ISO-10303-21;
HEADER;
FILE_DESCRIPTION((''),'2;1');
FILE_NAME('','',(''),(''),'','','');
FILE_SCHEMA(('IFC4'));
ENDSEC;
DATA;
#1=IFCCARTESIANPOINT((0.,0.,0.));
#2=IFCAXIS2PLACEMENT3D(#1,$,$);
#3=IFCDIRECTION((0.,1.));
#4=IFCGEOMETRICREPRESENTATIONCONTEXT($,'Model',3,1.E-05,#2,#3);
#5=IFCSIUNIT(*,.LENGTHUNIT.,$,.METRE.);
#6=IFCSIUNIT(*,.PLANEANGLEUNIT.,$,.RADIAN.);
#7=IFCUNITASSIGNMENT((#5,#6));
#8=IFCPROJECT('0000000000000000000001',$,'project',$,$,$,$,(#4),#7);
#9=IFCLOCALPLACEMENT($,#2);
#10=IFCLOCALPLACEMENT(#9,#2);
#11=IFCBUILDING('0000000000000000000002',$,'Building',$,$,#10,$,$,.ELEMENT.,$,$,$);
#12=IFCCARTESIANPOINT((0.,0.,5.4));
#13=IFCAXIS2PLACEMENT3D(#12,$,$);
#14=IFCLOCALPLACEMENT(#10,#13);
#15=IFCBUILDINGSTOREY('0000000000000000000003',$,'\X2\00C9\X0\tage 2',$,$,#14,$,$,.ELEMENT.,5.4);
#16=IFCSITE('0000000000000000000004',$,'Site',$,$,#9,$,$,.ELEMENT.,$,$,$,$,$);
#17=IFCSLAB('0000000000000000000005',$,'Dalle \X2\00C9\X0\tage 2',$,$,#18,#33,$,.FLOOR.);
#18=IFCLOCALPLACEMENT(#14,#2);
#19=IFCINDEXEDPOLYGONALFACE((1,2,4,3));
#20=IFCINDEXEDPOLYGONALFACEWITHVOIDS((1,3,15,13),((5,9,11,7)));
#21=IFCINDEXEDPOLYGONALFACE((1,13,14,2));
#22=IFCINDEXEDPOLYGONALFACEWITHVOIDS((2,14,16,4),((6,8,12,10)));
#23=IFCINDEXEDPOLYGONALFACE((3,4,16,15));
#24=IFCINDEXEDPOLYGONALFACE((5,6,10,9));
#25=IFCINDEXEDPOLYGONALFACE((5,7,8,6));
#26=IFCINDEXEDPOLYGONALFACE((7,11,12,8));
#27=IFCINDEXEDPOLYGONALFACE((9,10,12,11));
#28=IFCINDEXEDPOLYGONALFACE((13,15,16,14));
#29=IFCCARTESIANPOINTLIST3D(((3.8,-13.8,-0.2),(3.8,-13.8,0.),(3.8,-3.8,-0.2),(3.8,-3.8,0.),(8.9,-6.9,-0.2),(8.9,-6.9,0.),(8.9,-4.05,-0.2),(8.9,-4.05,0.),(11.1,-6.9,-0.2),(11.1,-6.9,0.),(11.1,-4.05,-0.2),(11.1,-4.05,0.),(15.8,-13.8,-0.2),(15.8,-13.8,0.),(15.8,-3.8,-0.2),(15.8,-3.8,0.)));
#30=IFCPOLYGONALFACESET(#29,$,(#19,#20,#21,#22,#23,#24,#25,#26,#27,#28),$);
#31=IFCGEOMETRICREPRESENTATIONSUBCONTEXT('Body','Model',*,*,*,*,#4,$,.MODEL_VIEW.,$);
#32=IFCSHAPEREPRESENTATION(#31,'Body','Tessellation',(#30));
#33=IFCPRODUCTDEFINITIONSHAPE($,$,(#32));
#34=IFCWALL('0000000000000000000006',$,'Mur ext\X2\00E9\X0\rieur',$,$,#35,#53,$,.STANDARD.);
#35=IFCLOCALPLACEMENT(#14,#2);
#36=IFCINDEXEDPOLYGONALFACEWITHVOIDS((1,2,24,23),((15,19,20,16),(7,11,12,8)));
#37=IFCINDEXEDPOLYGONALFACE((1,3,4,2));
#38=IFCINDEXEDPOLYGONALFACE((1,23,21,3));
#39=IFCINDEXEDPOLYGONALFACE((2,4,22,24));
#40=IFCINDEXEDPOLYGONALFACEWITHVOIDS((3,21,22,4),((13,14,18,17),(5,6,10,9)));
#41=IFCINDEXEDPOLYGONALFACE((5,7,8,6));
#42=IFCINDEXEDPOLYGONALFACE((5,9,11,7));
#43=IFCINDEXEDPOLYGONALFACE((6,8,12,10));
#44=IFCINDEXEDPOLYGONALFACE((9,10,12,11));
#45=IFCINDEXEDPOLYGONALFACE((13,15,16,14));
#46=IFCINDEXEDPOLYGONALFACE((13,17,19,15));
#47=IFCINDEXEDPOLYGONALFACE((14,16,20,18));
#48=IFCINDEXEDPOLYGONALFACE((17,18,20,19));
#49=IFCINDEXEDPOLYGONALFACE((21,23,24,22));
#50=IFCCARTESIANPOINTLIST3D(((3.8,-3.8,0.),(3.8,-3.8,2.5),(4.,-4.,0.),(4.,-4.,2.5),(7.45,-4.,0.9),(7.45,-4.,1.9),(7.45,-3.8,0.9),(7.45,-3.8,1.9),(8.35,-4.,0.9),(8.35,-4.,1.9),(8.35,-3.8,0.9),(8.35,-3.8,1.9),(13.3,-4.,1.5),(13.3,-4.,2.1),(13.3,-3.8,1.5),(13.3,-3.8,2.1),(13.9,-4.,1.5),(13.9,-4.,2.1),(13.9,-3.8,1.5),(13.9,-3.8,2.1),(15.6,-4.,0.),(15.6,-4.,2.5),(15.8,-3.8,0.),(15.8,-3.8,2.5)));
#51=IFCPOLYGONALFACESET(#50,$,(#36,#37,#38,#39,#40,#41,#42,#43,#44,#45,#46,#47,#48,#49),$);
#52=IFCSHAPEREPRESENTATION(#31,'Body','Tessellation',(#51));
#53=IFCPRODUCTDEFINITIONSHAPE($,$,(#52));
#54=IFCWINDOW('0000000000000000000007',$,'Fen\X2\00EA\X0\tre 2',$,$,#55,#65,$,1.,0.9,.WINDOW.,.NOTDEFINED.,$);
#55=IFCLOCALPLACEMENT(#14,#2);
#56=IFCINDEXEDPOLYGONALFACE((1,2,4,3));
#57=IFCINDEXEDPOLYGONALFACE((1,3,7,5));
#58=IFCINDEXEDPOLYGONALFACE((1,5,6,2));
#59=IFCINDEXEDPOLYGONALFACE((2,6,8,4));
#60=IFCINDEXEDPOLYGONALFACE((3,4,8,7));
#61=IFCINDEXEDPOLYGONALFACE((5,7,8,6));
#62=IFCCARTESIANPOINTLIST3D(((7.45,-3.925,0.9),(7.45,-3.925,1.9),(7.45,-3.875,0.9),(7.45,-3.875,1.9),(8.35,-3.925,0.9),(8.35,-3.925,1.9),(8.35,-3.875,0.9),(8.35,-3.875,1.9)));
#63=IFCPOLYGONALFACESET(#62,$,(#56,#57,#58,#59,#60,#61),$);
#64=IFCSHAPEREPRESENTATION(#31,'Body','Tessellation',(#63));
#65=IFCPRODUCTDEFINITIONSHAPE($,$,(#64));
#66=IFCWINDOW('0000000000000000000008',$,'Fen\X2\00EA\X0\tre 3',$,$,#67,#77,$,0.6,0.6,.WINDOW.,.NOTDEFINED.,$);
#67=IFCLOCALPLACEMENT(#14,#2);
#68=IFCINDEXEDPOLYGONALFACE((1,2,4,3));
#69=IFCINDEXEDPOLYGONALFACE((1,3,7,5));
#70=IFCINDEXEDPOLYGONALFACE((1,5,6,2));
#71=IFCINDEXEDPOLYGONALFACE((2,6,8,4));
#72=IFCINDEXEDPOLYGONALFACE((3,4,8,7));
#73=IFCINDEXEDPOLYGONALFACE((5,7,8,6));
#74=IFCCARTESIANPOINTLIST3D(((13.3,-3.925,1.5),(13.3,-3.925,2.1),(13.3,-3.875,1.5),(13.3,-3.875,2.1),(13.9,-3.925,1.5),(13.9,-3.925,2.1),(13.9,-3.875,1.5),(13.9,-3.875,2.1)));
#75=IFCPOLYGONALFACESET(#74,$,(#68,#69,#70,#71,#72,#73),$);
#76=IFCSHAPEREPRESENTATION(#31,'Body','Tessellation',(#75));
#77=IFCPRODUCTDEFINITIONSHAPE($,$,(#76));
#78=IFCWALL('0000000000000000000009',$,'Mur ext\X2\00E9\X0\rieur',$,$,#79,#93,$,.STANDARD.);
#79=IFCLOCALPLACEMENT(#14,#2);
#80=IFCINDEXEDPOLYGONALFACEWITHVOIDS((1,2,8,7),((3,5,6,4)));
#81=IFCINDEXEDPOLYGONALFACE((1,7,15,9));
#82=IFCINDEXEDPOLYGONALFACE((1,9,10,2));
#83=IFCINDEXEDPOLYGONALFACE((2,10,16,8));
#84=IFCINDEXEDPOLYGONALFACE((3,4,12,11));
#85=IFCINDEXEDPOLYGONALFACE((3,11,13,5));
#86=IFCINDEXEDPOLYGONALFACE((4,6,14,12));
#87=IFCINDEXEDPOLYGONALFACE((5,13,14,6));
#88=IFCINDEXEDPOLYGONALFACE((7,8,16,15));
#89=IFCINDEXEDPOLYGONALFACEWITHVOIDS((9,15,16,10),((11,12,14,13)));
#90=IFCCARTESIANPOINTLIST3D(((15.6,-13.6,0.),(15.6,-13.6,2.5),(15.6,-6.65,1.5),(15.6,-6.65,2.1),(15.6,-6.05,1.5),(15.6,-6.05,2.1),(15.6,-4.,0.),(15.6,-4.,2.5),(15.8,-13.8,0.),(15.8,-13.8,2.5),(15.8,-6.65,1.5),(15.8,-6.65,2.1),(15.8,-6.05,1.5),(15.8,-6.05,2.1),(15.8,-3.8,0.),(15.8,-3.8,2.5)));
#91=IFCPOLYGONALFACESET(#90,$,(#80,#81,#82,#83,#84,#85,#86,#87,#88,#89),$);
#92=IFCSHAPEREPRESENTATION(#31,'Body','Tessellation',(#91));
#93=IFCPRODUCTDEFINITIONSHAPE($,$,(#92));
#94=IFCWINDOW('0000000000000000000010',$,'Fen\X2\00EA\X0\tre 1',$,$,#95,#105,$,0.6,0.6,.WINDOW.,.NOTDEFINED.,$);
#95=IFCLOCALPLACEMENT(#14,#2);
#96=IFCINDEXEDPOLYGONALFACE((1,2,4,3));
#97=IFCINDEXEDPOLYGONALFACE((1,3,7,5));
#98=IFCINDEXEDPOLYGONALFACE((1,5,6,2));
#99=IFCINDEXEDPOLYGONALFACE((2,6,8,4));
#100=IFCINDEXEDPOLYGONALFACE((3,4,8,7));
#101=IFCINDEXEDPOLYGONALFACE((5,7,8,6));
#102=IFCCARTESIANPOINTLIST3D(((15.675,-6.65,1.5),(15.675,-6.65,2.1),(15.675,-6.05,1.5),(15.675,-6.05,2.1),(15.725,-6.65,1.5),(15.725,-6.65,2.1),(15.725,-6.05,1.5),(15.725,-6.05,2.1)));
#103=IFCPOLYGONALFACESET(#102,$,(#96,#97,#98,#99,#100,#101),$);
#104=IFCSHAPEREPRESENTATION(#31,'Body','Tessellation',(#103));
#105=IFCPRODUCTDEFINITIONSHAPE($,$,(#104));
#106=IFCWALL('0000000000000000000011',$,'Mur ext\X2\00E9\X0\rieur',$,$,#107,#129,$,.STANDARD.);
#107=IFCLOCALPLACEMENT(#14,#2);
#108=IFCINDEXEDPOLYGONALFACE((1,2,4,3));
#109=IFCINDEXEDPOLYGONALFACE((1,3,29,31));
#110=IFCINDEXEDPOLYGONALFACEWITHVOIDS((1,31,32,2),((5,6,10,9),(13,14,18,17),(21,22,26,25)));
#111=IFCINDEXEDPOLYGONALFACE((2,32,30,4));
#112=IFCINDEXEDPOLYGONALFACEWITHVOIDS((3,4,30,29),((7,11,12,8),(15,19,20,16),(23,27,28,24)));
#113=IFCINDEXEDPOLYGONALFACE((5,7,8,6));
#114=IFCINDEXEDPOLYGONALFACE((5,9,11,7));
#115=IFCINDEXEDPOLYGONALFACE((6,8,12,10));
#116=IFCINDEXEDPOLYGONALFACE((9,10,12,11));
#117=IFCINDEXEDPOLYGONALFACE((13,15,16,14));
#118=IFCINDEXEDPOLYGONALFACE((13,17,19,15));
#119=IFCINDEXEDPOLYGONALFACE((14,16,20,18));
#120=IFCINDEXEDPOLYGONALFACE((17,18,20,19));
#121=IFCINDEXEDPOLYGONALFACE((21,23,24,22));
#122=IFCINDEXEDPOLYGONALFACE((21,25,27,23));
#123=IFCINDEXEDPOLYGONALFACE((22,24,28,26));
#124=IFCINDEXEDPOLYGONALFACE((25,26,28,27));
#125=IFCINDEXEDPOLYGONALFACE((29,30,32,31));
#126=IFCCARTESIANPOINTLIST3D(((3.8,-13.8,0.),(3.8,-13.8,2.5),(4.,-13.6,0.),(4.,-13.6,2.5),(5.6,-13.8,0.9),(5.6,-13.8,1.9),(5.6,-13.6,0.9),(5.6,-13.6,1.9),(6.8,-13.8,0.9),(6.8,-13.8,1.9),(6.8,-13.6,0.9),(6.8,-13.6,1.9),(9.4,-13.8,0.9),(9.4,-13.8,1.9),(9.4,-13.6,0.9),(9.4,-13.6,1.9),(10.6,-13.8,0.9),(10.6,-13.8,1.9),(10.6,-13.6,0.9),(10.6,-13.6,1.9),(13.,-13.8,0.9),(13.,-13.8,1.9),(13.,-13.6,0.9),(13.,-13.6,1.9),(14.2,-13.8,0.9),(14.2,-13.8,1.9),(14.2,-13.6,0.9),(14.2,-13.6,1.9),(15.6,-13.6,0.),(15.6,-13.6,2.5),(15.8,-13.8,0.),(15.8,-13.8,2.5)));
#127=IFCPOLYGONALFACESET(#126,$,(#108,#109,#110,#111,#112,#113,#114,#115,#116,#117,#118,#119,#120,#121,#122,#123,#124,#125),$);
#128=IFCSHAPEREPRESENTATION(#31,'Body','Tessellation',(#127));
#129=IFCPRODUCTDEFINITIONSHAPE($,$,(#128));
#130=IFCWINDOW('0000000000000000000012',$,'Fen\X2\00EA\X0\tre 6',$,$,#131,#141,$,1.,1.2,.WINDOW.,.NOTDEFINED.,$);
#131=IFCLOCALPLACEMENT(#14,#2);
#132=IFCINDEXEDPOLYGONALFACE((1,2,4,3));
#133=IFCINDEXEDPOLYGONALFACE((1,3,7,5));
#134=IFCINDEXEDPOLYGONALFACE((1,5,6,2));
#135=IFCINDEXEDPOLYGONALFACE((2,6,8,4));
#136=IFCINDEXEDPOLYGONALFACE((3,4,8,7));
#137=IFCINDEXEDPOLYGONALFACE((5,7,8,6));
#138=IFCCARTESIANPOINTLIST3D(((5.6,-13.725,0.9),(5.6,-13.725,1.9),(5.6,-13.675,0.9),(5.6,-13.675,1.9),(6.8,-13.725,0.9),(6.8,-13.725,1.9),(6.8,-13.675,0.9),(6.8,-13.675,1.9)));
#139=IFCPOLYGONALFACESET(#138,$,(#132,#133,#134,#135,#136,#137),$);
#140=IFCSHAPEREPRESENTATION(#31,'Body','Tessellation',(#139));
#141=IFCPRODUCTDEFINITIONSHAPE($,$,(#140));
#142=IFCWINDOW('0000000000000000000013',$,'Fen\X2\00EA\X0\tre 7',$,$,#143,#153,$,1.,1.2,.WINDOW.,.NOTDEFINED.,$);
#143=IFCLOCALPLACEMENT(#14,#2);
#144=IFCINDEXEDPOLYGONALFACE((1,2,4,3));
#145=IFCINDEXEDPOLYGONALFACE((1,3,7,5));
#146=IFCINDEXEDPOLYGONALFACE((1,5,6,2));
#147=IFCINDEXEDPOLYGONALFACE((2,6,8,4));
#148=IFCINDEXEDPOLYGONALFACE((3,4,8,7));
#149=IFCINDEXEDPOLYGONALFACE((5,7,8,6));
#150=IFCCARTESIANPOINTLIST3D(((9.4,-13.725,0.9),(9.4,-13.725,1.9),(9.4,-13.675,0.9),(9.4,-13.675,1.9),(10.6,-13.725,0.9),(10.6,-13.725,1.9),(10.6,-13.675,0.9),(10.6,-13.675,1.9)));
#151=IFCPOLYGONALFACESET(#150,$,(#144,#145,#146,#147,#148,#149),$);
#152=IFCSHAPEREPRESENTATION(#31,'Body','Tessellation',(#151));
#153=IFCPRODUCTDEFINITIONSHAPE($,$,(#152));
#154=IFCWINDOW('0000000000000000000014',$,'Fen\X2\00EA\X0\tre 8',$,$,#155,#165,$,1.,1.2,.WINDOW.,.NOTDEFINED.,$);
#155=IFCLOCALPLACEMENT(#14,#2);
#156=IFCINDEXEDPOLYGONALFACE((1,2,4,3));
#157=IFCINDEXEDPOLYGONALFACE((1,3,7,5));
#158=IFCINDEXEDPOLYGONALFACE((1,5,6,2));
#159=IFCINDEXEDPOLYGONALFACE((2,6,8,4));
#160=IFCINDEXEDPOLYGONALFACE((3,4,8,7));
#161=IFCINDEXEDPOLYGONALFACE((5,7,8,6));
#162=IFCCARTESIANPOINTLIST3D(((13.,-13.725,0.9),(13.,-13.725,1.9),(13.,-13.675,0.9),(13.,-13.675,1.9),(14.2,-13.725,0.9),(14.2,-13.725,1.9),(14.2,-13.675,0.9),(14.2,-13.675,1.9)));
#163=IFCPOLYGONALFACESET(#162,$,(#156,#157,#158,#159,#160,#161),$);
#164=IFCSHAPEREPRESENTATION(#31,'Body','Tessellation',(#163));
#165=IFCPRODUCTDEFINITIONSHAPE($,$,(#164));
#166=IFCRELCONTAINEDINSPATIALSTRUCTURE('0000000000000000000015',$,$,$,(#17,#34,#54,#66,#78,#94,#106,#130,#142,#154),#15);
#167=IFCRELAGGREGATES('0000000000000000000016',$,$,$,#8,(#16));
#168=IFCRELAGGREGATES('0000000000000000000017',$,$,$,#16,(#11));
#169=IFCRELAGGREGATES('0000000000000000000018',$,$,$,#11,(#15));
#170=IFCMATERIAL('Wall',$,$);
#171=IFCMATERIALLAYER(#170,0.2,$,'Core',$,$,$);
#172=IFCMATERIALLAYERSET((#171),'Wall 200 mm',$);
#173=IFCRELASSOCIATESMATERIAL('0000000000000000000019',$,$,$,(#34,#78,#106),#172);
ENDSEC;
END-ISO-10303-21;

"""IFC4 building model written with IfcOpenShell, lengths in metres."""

from ifc_helpers import new_model, si_unit, direction, frame, origin, origin_2d, place, context, subcontext, project, spatial, polyline, rectangle, outline, extrude, material, layer, layer_set, layer_usage, element, fill, save


model = new_model("IFC4")

# Units and contexts
model_context = context("Model", 3, precision=1e-05, world=origin(), true_north=direction((0.0, 1.0)))
body_context = subcontext(model_context, "Body", "Model", "MODEL_VIEW")
ifc_project = project(units=[si_unit("LENGTHUNIT", "METRE"), si_unit("PLANEANGLEUNIT", "RADIAN")], contexts=[model_context])

# Site, building, storey
site_placement = place(None, origin())
site = spatial("IfcSite", under=ifc_project, at=site_placement, Name="Site", CompositionType="ELEMENT")
building_placement = place(site_placement, origin())
building = spatial("IfcBuilding", under=site, at=building_placement, Name="Building", CompositionType="ELEMENT")
storey_placement = place(building_placement, frame((0.0, 0.0, 5.4)))
storey = spatial("IfcBuildingStorey", under=building, at=storey_placement, Name="Étage 2", CompositionType="ELEMENT", Elevation=5.4)

# Slab
slab_placement = place(storey_placement, origin())
element("IfcSlab", 1, at=slab_placement, inside=storey, Name="Dalle Étage 2", PredefinedType="FLOOR", context=body_context, shape_type="SweptSolid", body=[
    extrude(outline(polyline([(3.8, -13.8), (15.8, -13.8), (15.8, -3.8), (3.8, -3.8), (3.8, -13.8)]), holes=[polyline([(11.1, -4.05), (11.1, -6.9), (8.9, -6.9), (8.9, -4.05), (11.1, -4.05)])]), frame((0.0, 0.0, -0.2)), (0.0, 0.0, 1.0), 0.2),
])

# Wall, openings, windows
ifc_material = material(Name="Wall")
ifc_layer = layer(ifc_material, 0.2, Name="Core")
ifc_layer_set = layer_set([ifc_layer], Name="Wall 200 mm")
ifc_layer_usage = layer_usage(ifc_layer_set, "AXIS2", "POSITIVE", -0.1)
wall_1_placement = place(storey_placement, frame((3.9, -3.9, 0.0)))
wall_1 = element("IfcWall", 2, at=wall_1_placement, inside=storey, material=ifc_layer_usage, Name="Mur extérieur", PredefinedType="STANDARD", context=body_context, shape_type="SweptSolid", body=[
    extrude(outline(polyline([(0.0, 0.0), (0.1, -0.1), (11.7, -0.1), (11.8, 0.0), (11.9, 0.1), (-0.1, 0.1), (0.0, 0.0)])), origin(), (0.0, 0.0, 1.0), 2.5),
])
opening_1_placement = place(wall_1_placement, frame((4.0, 0.0, 0.9)))
opening_1 = element("IfcOpeningElement", 3, at=opening_1_placement, cuts=wall_1, PredefinedType="OPENING", context=body_context, shape_type="SweptSolid", body=[
    extrude(rectangle(XDim=0.9, YDim=0.4, at=origin_2d()), origin(), (0.0, 0.0, 1.0), 1.0),
])
opening_2_placement = place(wall_1_placement, frame((9.7, 0.0, 1.5)))
opening_2 = element("IfcOpeningElement", 4, at=opening_2_placement, cuts=wall_1, PredefinedType="OPENING", context=body_context, shape_type="SweptSolid", body=[
    extrude(rectangle(XDim=0.6, YDim=0.4, at=origin_2d()), origin(), (0.0, 0.0, 1.0), 0.6),
])
window_1_placement = place(opening_1_placement, origin())
window_1 = element("IfcWindow", 5, at=window_1_placement, inside=storey, Name="Fenêtre 2", OverallHeight=1.0, OverallWidth=0.9, PartitioningType="NOTDEFINED", PredefinedType="WINDOW", context=body_context, shape_type="SweptSolid", body=[
    extrude(rectangle(XDim=0.9, YDim=0.05, at=origin_2d()), origin(), (0.0, 0.0, 1.0), 1.0),
])
fill(opening_1, window_1)
window_2_placement = place(opening_2_placement, origin())
window_2 = element("IfcWindow", 6, at=window_2_placement, inside=storey, Name="Fenêtre 3", OverallHeight=0.6, OverallWidth=0.6, PartitioningType="NOTDEFINED", PredefinedType="WINDOW", context=body_context, shape_type="SweptSolid", body=[
    extrude(rectangle(XDim=0.6, YDim=0.05, at=origin_2d()), origin(), (0.0, 0.0, 1.0), 0.6),
])
fill(opening_2, window_2)

# Wall, opening, window
wall_2_placement = place(storey_placement, frame((15.7, -3.9, 0.0), z_axis=(0.0, 0.0, 1.0), x_axis=(0.0, -1.0, 0.0)))
wall_2 = element("IfcWall", 7, at=wall_2_placement, inside=storey, material=ifc_layer_usage, Name="Mur extérieur", PredefinedType="STANDARD", context=body_context, shape_type="SweptSolid", body=[
    extrude(outline(polyline([(0.0, 0.0), (0.1, -0.1), (9.7, -0.1), (9.8, 0.0), (9.9, 0.1), (-0.1, 0.1), (0.0, 0.0)])), origin(), (0.0, 0.0, 1.0), 2.5),
])
opening_3_placement = place(wall_2_placement, frame((2.45, 0.0, 1.5)))
opening_3 = element("IfcOpeningElement", 8, at=opening_3_placement, cuts=wall_2, PredefinedType="OPENING", context=body_context, shape_type="SweptSolid", body=[
    extrude(rectangle(XDim=0.6, YDim=0.4, at=origin_2d()), origin(), (0.0, 0.0, 1.0), 0.6),
])
window_3_placement = place(opening_3_placement, origin())
window_3 = element("IfcWindow", 9, at=window_3_placement, inside=storey, Name="Fenêtre 1", OverallHeight=0.6, OverallWidth=0.6, PartitioningType="NOTDEFINED", PredefinedType="WINDOW", context=body_context, shape_type="SweptSolid", body=[
    extrude(rectangle(XDim=0.6, YDim=0.05, at=origin_2d()), origin(), (0.0, 0.0, 1.0), 0.6),
])
fill(opening_3, window_3)

# Wall, openings, windows
wall_3_placement = place(storey_placement, frame((15.7, -13.7, 0.0), z_axis=(0.0, 0.0, 1.0), x_axis=(-1.0, 0.0, 0.0)))
wall_3 = element("IfcWall", 10, at=wall_3_placement, inside=storey, material=ifc_layer_usage, Name="Mur extérieur", PredefinedType="STANDARD", context=body_context, shape_type="SweptSolid", body=[
    extrude(outline(polyline([(0.0, 0.0), (0.1, -0.1), (11.7, -0.1), (11.8, 0.0), (11.9, 0.1), (-0.1, 0.1), (0.0, 0.0)])), origin(), (0.0, 0.0, 1.0), 2.5),
])
opening_4_placement = place(wall_3_placement, frame((9.5, 0.0, 0.9), z_axis=(0.0, 0.0, 1.0), x_axis=(1.0, 0.0, 0.0)))
opening_4 = element("IfcOpeningElement", 11, at=opening_4_placement, cuts=wall_3, PredefinedType="OPENING", context=body_context, shape_type="SweptSolid", body=[
    extrude(rectangle(XDim=1.2, YDim=0.4, at=origin_2d()), origin(), (0.0, 0.0, 1.0), 1.0),
])
opening_5_placement = place(wall_3_placement, frame((5.7, 0.0, 0.9), z_axis=(0.0, 0.0, 1.0), x_axis=(1.0, 0.0, 0.0)))
opening_5 = element("IfcOpeningElement", 12, at=opening_5_placement, cuts=wall_3, PredefinedType="OPENING", context=body_context, shape_type="SweptSolid", body=[
    extrude(rectangle(XDim=1.2, YDim=0.4, at=origin_2d()), origin(), (0.0, 0.0, 1.0), 1.0),
])
opening_6_placement = place(wall_3_placement, frame((2.1, 0.0, 0.9), z_axis=(0.0, 0.0, 1.0), x_axis=(1.0, 0.0, 0.0)))
opening_6 = element("IfcOpeningElement", 13, at=opening_6_placement, cuts=wall_3, PredefinedType="OPENING", context=body_context, shape_type="SweptSolid", body=[
    extrude(rectangle(XDim=1.2, YDim=0.4, at=origin_2d()), origin(), (0.0, 0.0, 1.0), 1.0),
])
window_4_placement = place(opening_4_placement, origin())
window_4 = element("IfcWindow", 14, at=window_4_placement, inside=storey, Name="Fenêtre 6", OverallHeight=1.0, OverallWidth=1.2, PartitioningType="NOTDEFINED", PredefinedType="WINDOW", context=body_context, shape_type="SweptSolid", body=[
    extrude(rectangle(XDim=1.2, YDim=0.05, at=origin_2d()), origin(), (0.0, 0.0, 1.0), 1.0),
])
fill(opening_4, window_4)
window_5_placement = place(opening_5_placement, origin())
window_5 = element("IfcWindow", 15, at=window_5_placement, inside=storey, Name="Fenêtre 7", OverallHeight=1.0, OverallWidth=1.2, PartitioningType="NOTDEFINED", PredefinedType="WINDOW", context=body_context, shape_type="SweptSolid", body=[
    extrude(rectangle(XDim=1.2, YDim=0.05, at=origin_2d()), origin(), (0.0, 0.0, 1.0), 1.0),
])
fill(opening_5, window_5)
window_6_placement = place(opening_6_placement, origin())
window_6 = element("IfcWindow", 16, at=window_6_placement, inside=storey, Name="Fenêtre 8", OverallHeight=1.0, OverallWidth=1.2, PartitioningType="NOTDEFINED", PredefinedType="WINDOW", context=body_context, shape_type="SweptSolid", body=[
    extrude(rectangle(XDim=1.2, YDim=0.05, at=origin_2d()), origin(), (0.0, 0.0, 1.0), 1.0),
])
fill(opening_6, window_6)

save(model, "model.ifc")
